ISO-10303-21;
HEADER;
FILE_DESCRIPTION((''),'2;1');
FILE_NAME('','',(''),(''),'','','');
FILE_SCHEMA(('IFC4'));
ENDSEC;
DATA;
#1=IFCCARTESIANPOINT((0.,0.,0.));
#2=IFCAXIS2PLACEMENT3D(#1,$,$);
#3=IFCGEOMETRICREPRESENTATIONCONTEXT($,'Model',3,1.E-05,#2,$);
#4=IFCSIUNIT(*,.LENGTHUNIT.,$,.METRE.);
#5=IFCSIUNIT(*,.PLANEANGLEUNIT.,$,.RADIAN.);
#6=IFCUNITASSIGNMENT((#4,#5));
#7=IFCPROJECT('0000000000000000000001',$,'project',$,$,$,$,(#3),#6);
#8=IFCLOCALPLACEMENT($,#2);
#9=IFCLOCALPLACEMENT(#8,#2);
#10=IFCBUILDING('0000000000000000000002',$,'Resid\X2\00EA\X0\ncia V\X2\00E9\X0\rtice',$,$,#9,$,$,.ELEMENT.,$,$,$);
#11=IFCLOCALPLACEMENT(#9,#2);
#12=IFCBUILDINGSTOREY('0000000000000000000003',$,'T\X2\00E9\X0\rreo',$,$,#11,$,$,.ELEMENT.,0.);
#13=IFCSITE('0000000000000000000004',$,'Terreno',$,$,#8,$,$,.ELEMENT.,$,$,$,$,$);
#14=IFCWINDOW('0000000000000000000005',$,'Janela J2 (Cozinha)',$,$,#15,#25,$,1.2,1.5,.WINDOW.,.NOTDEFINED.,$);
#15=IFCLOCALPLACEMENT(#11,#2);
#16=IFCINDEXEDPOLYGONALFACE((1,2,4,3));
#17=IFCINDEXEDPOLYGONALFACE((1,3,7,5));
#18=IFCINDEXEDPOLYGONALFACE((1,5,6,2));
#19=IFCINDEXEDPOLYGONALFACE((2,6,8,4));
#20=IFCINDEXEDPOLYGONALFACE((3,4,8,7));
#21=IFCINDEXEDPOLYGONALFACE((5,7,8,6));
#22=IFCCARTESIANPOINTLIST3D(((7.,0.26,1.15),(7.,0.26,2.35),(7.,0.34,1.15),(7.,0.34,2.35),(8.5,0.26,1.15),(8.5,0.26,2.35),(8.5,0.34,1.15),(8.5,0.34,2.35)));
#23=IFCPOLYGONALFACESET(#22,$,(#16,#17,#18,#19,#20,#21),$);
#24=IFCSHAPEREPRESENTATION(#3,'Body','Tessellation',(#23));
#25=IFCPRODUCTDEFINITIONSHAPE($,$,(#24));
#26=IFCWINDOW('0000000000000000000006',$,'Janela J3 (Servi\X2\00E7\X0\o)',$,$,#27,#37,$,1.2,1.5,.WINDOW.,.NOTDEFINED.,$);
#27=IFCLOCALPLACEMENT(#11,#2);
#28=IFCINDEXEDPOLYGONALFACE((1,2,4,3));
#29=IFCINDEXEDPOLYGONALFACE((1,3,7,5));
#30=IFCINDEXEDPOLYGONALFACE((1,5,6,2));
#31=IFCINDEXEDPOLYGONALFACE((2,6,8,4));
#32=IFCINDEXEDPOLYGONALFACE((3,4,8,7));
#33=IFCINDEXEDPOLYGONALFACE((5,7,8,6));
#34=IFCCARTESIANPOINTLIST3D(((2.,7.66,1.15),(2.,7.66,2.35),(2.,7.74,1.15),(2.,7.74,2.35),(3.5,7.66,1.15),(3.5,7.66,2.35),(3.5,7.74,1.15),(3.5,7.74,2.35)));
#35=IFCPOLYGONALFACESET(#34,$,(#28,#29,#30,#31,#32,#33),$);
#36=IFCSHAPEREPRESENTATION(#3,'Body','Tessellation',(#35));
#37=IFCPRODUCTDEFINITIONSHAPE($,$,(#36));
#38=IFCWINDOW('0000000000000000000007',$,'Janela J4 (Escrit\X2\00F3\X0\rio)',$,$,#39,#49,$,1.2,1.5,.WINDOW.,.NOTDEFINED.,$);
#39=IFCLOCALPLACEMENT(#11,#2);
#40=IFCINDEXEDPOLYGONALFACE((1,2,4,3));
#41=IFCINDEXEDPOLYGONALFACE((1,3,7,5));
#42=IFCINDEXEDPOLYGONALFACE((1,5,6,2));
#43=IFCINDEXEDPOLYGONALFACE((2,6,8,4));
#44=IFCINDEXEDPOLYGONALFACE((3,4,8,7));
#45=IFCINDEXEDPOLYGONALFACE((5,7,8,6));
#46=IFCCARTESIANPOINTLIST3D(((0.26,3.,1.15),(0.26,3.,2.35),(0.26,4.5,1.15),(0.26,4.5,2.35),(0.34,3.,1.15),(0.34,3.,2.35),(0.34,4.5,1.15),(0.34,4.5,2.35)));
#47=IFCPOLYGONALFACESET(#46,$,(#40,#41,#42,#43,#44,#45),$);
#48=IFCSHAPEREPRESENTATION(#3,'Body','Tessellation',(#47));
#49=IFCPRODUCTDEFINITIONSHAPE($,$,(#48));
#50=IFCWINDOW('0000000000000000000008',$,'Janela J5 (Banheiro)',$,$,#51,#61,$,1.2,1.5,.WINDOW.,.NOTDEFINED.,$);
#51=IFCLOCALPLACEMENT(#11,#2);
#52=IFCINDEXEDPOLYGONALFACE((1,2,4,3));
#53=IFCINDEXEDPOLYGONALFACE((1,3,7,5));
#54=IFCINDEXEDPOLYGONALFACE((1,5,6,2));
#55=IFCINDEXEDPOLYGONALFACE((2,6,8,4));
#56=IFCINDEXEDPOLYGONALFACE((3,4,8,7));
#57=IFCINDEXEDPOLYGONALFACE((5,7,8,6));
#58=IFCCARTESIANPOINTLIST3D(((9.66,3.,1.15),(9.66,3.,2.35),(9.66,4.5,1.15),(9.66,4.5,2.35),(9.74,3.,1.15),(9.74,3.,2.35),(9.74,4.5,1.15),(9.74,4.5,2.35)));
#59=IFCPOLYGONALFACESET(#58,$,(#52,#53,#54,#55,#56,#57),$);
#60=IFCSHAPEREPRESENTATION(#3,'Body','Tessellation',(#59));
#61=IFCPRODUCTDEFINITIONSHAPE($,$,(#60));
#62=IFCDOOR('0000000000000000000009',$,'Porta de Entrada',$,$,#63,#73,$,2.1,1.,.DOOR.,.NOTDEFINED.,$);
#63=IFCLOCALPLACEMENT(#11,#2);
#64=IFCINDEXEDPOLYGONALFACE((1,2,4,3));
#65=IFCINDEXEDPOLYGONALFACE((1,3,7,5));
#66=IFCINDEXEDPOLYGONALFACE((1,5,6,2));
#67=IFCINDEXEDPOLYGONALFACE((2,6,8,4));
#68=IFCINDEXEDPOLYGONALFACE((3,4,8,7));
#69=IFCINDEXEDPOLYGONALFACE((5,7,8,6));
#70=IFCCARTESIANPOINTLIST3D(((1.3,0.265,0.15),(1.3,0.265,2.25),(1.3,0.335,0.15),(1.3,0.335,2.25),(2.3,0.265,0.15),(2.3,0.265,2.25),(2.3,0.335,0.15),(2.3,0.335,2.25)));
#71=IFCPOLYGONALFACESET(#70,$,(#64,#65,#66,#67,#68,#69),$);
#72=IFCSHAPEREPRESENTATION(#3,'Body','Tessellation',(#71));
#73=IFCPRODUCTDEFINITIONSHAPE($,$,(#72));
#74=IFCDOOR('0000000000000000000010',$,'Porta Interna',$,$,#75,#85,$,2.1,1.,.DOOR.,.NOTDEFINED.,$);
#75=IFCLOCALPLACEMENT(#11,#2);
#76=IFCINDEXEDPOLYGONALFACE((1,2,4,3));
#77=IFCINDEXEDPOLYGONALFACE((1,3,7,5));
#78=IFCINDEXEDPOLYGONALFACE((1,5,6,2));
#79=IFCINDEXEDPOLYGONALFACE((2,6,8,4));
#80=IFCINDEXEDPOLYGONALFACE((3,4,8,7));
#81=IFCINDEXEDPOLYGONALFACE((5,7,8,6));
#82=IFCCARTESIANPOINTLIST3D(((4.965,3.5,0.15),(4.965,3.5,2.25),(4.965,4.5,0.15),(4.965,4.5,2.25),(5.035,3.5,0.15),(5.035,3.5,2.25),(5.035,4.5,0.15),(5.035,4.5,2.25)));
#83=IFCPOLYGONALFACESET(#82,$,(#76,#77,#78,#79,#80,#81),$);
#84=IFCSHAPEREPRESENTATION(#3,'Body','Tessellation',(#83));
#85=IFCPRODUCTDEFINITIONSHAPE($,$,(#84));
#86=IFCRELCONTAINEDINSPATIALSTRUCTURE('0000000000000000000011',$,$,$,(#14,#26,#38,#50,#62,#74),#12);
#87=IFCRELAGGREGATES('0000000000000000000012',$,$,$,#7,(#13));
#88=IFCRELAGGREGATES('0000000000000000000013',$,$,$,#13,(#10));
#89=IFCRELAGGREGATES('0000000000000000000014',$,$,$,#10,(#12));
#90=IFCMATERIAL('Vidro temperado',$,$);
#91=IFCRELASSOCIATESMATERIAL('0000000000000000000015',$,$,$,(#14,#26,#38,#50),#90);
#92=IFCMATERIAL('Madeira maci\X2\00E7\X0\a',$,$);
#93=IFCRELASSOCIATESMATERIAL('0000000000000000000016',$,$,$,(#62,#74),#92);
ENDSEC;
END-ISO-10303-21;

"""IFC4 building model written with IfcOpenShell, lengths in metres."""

from ifc_helpers import new_model, si_unit, frame, frame_2d, origin, place, context, project, spatial, rectangle, extrude, material, element, save


model = new_model("IFC4")

# Units and contexts
model_context = context("Model", 3, precision=1e-05, world=origin())
ifc_project = project(units=[si_unit("LENGTHUNIT", "METRE"), si_unit("PLANEANGLEUNIT", "RADIAN")], contexts=[model_context])

# Site, building, storey
site_placement = place(None, origin())
site = spatial("IfcSite", under=ifc_project, at=site_placement, Name="Terreno", CompositionType="ELEMENT")
building_placement = place(site_placement, origin())
building = spatial("IfcBuilding", under=site, at=building_placement, Name="Residência Vértice", CompositionType="ELEMENT")
storey_placement = place(building_placement, origin())
storey = spatial("IfcBuildingStorey", under=building, at=storey_placement, Name="Térreo", CompositionType="ELEMENT", Elevation=0.0)

# Windows
ifc_material_1 = material(Name="Vidro temperado")
window_1_placement = place(storey_placement, origin())
element("IfcWindow", 1, at=window_1_placement, inside=storey, material=ifc_material_1, Name="Janela J2 (Cozinha)", OverallHeight=1.2, OverallWidth=1.5, PartitioningType="NOTDEFINED", PredefinedType="WINDOW", context=model_context, shape_type="SweptSolid", body=[
    extrude(rectangle(XDim=1.5, YDim=0.08, at=frame_2d((7.75, 0.3))), frame((0.0, 0.0, 1.15)), (0.0, 0.0, 1.0), 1.2),
])
window_2_placement = place(storey_placement, origin())
element("IfcWindow", 2, at=window_2_placement, inside=storey, material=ifc_material_1, Name="Janela J3 (Serviço)", OverallHeight=1.2, OverallWidth=1.5, PartitioningType="NOTDEFINED", PredefinedType="WINDOW", context=model_context, shape_type="SweptSolid", body=[
    extrude(rectangle(XDim=1.5, YDim=0.08, at=frame_2d((2.75, 7.7))), frame((0.0, 0.0, 1.15)), (0.0, 0.0, 1.0), 1.2),
])
window_3_placement = place(storey_placement, origin())
element("IfcWindow", 3, at=window_3_placement, inside=storey, material=ifc_material_1, Name="Janela J4 (Escritório)", OverallHeight=1.2, OverallWidth=1.5, PartitioningType="NOTDEFINED", PredefinedType="WINDOW", context=model_context, shape_type="SweptSolid", body=[
    extrude(rectangle(XDim=0.08, YDim=1.5, at=frame_2d((0.3, 3.75))), frame((0.0, 0.0, 1.15)), (0.0, 0.0, 1.0), 1.2),
])
window_4_placement = place(storey_placement, origin())
element("IfcWindow", 4, at=window_4_placement, inside=storey, material=ifc_material_1, Name="Janela J5 (Banheiro)", OverallHeight=1.2, OverallWidth=1.5, PartitioningType="NOTDEFINED", PredefinedType="WINDOW", context=model_context, shape_type="SweptSolid", body=[
    extrude(rectangle(XDim=0.08, YDim=1.5, at=frame_2d((9.7, 3.75))), frame((0.0, 0.0, 1.15)), (0.0, 0.0, 1.0), 1.2),
])

# Doors
ifc_material_2 = material(Name="Madeira maciça")
door_1_placement = place(storey_placement, origin())
element("IfcDoor", 5, at=door_1_placement, inside=storey, material=ifc_material_2, Name="Porta de Entrada", OperationType="NOTDEFINED", OverallHeight=2.1, OverallWidth=1.0, PredefinedType="DOOR", context=model_context, shape_type="SweptSolid", body=[
    extrude(rectangle(XDim=1.0, YDim=0.07, at=frame_2d((1.8, 0.3))), frame((0.0, 0.0, 0.15)), (0.0, 0.0, 1.0), 2.1),
])
door_2_placement = place(storey_placement, origin())
element("IfcDoor", 6, at=door_2_placement, inside=storey, material=ifc_material_2, Name="Porta Interna", OperationType="NOTDEFINED", OverallHeight=2.1, OverallWidth=1.0, PredefinedType="DOOR", context=model_context, shape_type="SweptSolid", body=[
    extrude(rectangle(XDim=0.07, YDim=1.0, at=frame_2d((5.0, 4.0))), frame((0.0, 0.0, 0.15)), (0.0, 0.0, 1.0), 2.1),
])

save(model, "model.ifc")
